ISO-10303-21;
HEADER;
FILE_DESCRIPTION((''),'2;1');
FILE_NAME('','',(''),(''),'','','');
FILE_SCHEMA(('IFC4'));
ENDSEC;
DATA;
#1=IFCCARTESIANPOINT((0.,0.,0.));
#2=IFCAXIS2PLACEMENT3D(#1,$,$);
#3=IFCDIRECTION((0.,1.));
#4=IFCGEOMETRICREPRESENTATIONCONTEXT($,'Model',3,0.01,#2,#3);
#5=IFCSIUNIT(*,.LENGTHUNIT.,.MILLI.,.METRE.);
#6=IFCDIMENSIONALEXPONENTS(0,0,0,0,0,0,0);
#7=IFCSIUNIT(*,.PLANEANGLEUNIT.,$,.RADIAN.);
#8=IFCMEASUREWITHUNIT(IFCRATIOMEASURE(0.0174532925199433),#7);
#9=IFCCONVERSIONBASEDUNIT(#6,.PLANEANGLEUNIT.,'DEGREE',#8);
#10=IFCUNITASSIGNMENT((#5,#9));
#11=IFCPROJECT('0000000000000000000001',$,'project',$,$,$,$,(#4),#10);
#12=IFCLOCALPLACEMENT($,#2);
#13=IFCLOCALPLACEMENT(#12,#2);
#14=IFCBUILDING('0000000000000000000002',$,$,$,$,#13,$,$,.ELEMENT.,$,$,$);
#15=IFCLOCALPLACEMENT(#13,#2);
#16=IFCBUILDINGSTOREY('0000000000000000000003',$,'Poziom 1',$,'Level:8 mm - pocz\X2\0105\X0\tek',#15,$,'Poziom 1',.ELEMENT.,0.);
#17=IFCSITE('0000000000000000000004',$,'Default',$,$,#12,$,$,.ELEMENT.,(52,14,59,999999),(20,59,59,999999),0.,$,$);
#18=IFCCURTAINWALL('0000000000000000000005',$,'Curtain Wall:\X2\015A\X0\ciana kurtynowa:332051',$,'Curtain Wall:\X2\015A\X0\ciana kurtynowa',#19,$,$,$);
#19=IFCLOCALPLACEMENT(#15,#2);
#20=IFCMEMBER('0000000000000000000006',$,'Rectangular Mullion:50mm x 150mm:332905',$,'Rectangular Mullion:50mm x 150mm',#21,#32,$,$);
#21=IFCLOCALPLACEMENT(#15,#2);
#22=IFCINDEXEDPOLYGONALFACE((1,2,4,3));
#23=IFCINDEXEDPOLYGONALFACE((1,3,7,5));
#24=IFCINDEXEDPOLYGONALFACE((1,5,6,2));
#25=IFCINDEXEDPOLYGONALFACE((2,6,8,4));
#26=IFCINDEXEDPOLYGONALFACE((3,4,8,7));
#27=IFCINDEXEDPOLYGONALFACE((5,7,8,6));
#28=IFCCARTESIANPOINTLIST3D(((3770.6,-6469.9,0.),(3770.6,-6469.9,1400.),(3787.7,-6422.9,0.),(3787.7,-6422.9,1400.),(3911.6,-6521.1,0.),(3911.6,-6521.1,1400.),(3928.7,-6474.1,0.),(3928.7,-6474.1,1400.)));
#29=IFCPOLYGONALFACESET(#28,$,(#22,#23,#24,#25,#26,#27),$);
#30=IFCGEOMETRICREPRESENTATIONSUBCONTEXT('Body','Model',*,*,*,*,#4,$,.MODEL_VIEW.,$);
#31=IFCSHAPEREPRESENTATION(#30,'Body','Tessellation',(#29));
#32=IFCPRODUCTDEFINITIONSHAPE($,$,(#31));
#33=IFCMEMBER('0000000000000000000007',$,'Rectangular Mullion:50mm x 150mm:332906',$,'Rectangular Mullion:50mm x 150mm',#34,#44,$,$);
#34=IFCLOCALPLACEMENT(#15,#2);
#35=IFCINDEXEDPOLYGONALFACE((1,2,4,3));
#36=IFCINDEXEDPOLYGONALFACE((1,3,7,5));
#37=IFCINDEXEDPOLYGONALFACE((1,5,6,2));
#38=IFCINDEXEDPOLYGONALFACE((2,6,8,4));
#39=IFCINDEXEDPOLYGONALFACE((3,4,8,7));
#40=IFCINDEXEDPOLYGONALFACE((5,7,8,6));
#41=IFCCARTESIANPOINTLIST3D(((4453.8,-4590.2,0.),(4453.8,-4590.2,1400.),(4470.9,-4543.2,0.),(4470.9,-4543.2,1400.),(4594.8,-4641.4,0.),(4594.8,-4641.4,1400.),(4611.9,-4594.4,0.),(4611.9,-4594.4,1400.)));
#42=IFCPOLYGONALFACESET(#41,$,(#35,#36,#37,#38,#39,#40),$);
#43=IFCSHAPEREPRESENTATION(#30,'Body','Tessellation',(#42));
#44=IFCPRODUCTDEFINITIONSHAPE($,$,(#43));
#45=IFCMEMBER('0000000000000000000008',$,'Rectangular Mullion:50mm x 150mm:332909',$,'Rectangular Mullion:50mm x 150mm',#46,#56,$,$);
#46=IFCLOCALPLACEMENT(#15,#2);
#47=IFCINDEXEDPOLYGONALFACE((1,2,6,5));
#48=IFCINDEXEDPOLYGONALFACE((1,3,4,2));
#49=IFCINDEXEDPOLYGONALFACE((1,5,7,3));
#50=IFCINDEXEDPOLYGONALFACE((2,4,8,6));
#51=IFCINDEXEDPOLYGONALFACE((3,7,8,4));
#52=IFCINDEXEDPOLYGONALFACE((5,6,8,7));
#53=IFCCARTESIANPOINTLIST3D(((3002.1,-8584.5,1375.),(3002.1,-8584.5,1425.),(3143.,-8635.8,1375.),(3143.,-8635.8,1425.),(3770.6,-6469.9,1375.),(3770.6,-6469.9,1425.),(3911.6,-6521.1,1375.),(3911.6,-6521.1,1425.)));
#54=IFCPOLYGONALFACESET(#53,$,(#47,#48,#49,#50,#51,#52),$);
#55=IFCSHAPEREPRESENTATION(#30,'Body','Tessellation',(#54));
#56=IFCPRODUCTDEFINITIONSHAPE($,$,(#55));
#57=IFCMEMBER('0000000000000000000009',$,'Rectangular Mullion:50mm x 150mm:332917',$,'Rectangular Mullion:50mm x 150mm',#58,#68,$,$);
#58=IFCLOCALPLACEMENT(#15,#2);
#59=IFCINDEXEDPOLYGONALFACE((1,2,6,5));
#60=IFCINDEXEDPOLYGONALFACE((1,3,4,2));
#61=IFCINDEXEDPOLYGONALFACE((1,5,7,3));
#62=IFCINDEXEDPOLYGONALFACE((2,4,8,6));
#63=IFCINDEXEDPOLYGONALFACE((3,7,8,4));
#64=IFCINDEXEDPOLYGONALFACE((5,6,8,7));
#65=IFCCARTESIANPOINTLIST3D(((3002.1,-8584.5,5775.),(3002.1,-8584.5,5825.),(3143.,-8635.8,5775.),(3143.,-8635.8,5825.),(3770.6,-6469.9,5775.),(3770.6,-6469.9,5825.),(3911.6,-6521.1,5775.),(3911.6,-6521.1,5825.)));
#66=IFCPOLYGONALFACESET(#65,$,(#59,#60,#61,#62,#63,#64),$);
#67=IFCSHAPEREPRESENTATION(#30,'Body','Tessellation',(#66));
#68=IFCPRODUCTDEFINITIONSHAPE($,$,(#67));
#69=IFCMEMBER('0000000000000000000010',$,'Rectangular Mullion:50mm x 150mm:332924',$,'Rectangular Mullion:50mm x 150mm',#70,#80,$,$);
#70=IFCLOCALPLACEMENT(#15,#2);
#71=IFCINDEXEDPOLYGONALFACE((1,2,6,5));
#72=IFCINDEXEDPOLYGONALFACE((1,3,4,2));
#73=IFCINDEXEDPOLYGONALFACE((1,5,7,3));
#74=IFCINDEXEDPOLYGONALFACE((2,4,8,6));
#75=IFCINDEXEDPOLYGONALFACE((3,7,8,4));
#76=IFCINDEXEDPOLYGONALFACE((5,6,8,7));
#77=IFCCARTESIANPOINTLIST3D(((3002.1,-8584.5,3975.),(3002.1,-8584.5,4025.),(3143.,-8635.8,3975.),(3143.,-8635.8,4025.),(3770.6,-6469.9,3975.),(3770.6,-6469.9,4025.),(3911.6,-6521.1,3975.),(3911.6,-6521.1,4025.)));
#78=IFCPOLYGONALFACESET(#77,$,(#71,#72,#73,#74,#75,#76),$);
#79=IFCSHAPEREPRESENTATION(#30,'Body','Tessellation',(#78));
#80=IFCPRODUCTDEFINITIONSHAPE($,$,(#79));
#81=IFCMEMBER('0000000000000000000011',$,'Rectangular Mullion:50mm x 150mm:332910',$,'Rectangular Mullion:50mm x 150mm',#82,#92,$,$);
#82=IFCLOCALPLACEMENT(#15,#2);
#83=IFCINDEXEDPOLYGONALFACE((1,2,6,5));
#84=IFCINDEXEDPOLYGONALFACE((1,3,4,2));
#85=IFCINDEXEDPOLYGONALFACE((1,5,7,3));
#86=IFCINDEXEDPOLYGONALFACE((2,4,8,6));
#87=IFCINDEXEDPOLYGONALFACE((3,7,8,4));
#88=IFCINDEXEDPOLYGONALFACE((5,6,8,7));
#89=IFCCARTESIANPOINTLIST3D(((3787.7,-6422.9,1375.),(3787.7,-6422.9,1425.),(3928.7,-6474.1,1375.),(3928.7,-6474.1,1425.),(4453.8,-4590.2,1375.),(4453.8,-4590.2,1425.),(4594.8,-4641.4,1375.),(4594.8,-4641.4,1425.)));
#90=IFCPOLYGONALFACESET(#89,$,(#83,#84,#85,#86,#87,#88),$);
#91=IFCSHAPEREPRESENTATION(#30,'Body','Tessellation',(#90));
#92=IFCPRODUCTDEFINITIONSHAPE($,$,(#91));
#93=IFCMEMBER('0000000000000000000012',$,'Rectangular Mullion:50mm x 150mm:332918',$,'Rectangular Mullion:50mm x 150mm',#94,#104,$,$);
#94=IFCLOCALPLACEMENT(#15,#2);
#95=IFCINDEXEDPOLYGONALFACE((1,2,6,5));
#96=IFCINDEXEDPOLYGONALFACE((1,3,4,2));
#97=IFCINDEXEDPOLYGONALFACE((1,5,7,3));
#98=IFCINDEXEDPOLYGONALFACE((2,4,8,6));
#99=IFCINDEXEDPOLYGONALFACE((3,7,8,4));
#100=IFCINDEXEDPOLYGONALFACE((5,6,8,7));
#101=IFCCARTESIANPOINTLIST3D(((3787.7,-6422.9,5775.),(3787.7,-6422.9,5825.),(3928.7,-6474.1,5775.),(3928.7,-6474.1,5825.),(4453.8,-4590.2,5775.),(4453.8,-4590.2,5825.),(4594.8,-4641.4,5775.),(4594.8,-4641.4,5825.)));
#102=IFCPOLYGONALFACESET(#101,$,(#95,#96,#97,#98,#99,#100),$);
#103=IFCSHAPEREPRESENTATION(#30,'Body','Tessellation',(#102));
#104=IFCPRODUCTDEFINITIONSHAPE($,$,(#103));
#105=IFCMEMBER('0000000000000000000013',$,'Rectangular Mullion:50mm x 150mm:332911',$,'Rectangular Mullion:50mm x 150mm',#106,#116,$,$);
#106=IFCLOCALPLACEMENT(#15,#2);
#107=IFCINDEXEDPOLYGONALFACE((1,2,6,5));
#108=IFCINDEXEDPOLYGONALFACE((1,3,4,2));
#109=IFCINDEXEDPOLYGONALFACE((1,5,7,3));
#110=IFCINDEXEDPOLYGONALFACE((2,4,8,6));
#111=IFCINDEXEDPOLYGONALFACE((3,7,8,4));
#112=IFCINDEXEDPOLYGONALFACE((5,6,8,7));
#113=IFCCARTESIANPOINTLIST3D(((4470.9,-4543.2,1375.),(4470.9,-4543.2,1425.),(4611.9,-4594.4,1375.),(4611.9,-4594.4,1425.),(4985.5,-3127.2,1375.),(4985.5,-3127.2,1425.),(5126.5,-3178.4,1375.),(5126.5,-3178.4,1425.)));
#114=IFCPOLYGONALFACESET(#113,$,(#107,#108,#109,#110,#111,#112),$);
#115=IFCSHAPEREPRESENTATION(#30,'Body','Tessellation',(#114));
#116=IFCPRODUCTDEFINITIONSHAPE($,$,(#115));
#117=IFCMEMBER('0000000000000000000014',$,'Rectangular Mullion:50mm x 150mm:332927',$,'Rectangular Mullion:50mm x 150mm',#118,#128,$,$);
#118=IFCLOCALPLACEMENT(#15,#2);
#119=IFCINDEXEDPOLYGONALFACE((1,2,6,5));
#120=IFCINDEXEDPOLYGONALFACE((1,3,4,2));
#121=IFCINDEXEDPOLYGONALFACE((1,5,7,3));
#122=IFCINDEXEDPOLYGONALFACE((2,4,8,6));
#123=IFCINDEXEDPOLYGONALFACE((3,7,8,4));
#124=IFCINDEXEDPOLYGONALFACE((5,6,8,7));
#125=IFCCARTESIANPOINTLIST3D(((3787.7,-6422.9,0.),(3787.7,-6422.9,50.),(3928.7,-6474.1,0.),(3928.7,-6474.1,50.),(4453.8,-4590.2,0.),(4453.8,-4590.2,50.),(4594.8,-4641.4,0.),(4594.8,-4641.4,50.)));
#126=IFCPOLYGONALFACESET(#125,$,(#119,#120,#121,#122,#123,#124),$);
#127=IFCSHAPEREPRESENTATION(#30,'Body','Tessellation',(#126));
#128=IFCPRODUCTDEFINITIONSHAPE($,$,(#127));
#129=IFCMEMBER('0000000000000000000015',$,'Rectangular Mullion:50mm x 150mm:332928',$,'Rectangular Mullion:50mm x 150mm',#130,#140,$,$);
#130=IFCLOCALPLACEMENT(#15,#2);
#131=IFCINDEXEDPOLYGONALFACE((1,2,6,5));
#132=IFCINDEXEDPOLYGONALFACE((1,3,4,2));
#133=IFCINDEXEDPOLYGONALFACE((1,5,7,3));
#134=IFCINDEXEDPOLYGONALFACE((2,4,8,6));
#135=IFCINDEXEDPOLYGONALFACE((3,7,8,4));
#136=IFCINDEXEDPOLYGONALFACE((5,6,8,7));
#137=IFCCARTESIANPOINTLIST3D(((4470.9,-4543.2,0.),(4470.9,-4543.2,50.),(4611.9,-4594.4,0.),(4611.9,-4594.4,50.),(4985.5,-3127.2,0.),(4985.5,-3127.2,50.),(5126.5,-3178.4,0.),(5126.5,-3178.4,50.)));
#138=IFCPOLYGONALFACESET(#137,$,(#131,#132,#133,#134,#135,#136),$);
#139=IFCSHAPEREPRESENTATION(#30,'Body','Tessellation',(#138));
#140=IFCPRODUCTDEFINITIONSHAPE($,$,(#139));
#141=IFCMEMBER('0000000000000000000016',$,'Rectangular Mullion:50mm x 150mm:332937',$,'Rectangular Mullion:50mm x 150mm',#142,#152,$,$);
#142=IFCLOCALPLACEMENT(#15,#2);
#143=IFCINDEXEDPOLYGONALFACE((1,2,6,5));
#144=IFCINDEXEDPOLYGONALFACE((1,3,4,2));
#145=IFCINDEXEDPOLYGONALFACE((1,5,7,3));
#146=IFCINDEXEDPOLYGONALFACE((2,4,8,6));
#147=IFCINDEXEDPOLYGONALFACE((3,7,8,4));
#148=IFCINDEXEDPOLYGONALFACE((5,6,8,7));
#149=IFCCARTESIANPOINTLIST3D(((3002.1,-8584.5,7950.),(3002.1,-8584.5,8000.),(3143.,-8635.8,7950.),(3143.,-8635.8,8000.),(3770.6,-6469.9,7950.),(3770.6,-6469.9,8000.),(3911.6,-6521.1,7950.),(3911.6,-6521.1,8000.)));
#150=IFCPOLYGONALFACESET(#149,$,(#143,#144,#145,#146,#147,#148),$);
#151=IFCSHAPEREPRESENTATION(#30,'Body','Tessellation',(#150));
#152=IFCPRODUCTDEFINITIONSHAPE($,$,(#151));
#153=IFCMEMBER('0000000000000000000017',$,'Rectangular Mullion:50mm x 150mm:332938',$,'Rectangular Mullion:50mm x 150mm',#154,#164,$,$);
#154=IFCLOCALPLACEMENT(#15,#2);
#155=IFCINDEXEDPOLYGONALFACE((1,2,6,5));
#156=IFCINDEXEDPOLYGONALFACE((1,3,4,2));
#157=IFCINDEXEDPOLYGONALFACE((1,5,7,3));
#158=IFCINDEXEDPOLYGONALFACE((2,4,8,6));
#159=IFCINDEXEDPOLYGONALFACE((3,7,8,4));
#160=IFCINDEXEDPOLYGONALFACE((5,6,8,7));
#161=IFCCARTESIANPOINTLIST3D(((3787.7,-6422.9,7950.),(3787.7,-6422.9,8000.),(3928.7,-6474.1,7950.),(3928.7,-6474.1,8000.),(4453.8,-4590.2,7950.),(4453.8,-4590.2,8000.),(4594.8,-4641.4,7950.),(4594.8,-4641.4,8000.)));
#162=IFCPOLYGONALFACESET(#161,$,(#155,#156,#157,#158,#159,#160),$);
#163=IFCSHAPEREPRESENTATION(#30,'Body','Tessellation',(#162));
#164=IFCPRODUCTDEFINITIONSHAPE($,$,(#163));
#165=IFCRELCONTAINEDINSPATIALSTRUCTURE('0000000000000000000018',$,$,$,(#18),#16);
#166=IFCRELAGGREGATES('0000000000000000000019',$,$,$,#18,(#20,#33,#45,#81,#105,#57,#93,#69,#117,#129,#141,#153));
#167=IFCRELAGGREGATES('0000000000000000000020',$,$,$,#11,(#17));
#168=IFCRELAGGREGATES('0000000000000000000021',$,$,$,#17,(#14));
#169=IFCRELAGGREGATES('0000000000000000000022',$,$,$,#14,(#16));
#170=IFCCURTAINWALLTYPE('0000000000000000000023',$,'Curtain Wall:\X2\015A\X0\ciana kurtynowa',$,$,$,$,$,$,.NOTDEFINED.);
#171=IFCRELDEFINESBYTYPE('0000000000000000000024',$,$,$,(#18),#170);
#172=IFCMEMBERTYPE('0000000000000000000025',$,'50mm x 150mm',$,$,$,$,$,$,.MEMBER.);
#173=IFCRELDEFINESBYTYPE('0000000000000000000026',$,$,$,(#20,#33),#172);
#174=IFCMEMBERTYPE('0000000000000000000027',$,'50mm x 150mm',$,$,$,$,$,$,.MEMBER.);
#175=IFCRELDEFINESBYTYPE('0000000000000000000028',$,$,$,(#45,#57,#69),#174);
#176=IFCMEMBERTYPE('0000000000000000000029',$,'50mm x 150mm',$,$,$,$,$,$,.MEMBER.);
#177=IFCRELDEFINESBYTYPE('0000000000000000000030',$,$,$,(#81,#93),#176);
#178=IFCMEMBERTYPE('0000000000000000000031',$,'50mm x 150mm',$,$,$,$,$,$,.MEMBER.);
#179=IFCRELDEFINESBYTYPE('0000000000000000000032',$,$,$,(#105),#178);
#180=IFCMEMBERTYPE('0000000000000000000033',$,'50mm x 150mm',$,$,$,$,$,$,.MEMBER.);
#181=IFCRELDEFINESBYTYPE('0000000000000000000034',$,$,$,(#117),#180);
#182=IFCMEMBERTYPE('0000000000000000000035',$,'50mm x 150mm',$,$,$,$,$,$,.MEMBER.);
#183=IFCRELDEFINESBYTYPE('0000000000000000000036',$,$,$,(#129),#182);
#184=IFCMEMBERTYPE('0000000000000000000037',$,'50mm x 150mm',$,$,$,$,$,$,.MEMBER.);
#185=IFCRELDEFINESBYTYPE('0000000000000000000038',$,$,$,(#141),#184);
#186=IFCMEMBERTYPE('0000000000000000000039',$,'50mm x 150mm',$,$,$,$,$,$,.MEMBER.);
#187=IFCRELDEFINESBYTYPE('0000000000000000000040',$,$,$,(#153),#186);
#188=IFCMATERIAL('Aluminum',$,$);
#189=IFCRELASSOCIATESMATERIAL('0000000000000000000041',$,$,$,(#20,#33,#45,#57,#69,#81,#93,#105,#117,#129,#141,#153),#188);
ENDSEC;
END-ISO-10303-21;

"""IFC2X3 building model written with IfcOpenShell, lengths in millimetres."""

from ifc_helpers import new_model, entity, si_unit, converted_unit, direction, frame, origin, origin_2d_with_axis, place, context, subcontext, project, spatial, rectangle, extrude, source, transform, mapped, material, type_object, type_shapes, element, aggregate, save


model = new_model("IFC2X3")

# Units and contexts
model_context = context("Model", 3, precision=0.01, world=origin(), true_north=direction((0.0, 1.0)))
body_context = subcontext(model_context, "Body", "Model", "MODEL_VIEW")
ifc_project = project(units=[si_unit("LENGTHUNIT", "METRE", prefix="MILLI"), converted_unit("PLANEANGLEUNIT", "DEGREE", entity("IfcRatioMeasure", 0.0174532925199433), si_unit("PLANEANGLEUNIT", "RADIAN"), dimensions=[0, 0, 0, 0, 0, 0, 0])], contexts=[model_context])

# Site, building, storey
site_placement = place(None, origin())
site = spatial("IfcSite", under=ifc_project, at=site_placement, Name="Default", CompositionType="ELEMENT", RefLatitude=(52, 14, 59, 999999), RefLongitude=(20, 59, 59, 999999), RefElevation=0.0)
building_placement = place(site_placement, origin())
building = spatial("IfcBuilding", under=site, at=building_placement, CompositionType="ELEMENT")
storey_placement = place(building_placement, origin())
storey = spatial("IfcBuildingStorey", under=building, at=storey_placement, Name="Poziom 1", ObjectType="Level:8 mm - początek", LongName="Poziom 1", CompositionType="ELEMENT", Elevation=0.0)

# Curtain wall, members
curtain_wall_type = type_object("IfcCurtainWallType", Name="Curtain Wall:Ściana kurtynowa", PredefinedType="NOTDEFINED")
curtain_wall_placement = place(storey_placement, origin())
curtain_wall = element("IfcCurtainWall", 1, at=curtain_wall_placement, inside=storey, type_object=curtain_wall_type, Name="Curtain Wall:Ściana kurtynowa:332051", ObjectType="Curtain Wall:Ściana kurtynowa")
ifc_material_1 = material(Name="Aluminum")
member_type_1 = type_object("IfcMemberType", Name="50mm x 150mm", PredefinedType="MEMBER")
shared_shape_1 = source(origin(), body_context, "Body", "SweptSolid", [
    extrude(rectangle(XDim=150.0, YDim=50.0, at=origin_2d_with_axis()), frame((0.0, 0.0, -1400.0), z_axis=(0.0, 0.0, 1.0), x_axis=(0.0, -1.0, 0.0)), (0.0, 0.0, 1.0), 1400.0),
])
type_shapes(member_type_1, [shared_shape_1])
member_1_placement = place(storey_placement, frame((3849.7, -6472.0, 0.0), z_axis=(0.0, 0.0, -1.0), x_axis=(0.341586, 0.939851, 0.0)))
member_1 = element("IfcMember", 2, at=member_1_placement, type_object=member_type_1, material=ifc_material_1, Name="Rectangular Mullion:50mm x 150mm:332905", ObjectType="Rectangular Mullion:50mm x 150mm", context=body_context, shape_type="MappedRepresentation", body=[
    mapped(shared_shape_1, transform((0.0, 0.0, 0.0), scale=1.0)),
])
member_2_placement = place(storey_placement, frame((4532.8, -4592.3, 0.0), z_axis=(0.0, 0.0, -1.0), x_axis=(0.341586, 0.939851, 0.0)))
member_2 = element("IfcMember", 3, at=member_2_placement, type_object=member_type_1, material=ifc_material_1, Name="Rectangular Mullion:50mm x 150mm:332906", ObjectType="Rectangular Mullion:50mm x 150mm", context=body_context, shape_type="MappedRepresentation", body=[
    mapped(shared_shape_1, transform((0.0, 0.0, 0.0), scale=1.0)),
])
member_type_2 = type_object("IfcMemberType", Name="50mm x 150mm", PredefinedType="MEMBER")
shared_shape_2 = source(origin(), body_context, "Body", "SweptSolid", [
    extrude(rectangle(XDim=150.0, YDim=50.0, at=origin_2d_with_axis()), frame((0.0, 0.0, -2250.0), z_axis=(0.0, 0.0, 1.0), x_axis=(0.0, -1.0, 0.0)), (0.0, 0.0, 1.0), 2250.0),
])
type_shapes(member_type_2, [shared_shape_2])
member_3_placement = place(storey_placement, frame((3841.1, -6495.5, 1400.0), z_axis=(0.341586, 0.939851, 0.0), x_axis=(0.0, 0.0, 1.0)))
member_3 = element("IfcMember", 4, at=member_3_placement, type_object=member_type_2, material=ifc_material_1, Name="Rectangular Mullion:50mm x 150mm:332909", ObjectType="Rectangular Mullion:50mm x 150mm", context=body_context, shape_type="MappedRepresentation", body=[
    mapped(shared_shape_2, transform((0.0, 0.0, 0.0), scale=1.0)),
])
member_4_placement = place(storey_placement, frame((3841.1, -6495.5, 5800.0), z_axis=(0.341586, 0.939851, 0.0), x_axis=(0.0, 0.0, 1.0)))
member_4 = element("IfcMember", 5, at=member_4_placement, type_object=member_type_2, material=ifc_material_1, Name="Rectangular Mullion:50mm x 150mm:332917", ObjectType="Rectangular Mullion:50mm x 150mm", context=body_context, shape_type="MappedRepresentation", body=[
    mapped(shared_shape_2, transform((0.0, 0.0, 0.0), scale=1.0)),
])
member_5_placement = place(storey_placement, frame((3841.1, -6495.5, 4000.0), z_axis=(0.341586, 0.939851, 0.0), x_axis=(0.0, 0.0, 1.0)))
member_5 = element("IfcMember", 6, at=member_5_placement, type_object=member_type_2, material=ifc_material_1, Name="Rectangular Mullion:50mm x 150mm:332924", ObjectType="Rectangular Mullion:50mm x 150mm", context=body_context, shape_type="MappedRepresentation", body=[
    mapped(shared_shape_2, transform((0.0, 0.0, 0.0), scale=1.0)),
])
member_type_3 = type_object("IfcMemberType", Name="50mm x 150mm", PredefinedType="MEMBER")
shared_shape_3 = source(origin(), body_context, "Body", "SweptSolid", [
    extrude(rectangle(XDim=150.0, YDim=50.0, at=origin_2d_with_axis()), frame((0.0, 0.0, -1950.0), z_axis=(0.0, 0.0, 1.0), x_axis=(0.0, -1.0, 0.0)), (0.0, 0.0, 1.0), 1950.0),
])
type_shapes(member_type_3, [shared_shape_3])
member_6_placement = place(storey_placement, frame((4524.3, -4615.8, 1400.0), z_axis=(0.341586, 0.939851, 0.0), x_axis=(0.0, 0.0, 1.0)))
member_6 = element("IfcMember", 7, at=member_6_placement, type_object=member_type_3, material=ifc_material_1, Name="Rectangular Mullion:50mm x 150mm:332910", ObjectType="Rectangular Mullion:50mm x 150mm", context=body_context, shape_type="MappedRepresentation", body=[
    mapped(shared_shape_3, transform((0.0, 0.0, 0.0), scale=1.0)),
])
member_7_placement = place(storey_placement, frame((4524.3, -4615.8, 5800.0), z_axis=(0.341586, 0.939851, 0.0), x_axis=(0.0, 0.0, 1.0)))
member_7 = element("IfcMember", 8, at=member_7_placement, type_object=member_type_3, material=ifc_material_1, Name="Rectangular Mullion:50mm x 150mm:332918", ObjectType="Rectangular Mullion:50mm x 150mm", context=body_context, shape_type="MappedRepresentation", body=[
    mapped(shared_shape_3, transform((0.0, 0.0, 0.0), scale=1.0)),
])
member_type_4 = type_object("IfcMemberType", Name="50mm x 150mm", PredefinedType="MEMBER")
shared_shape_4 = source(origin(), body_context, "Body", "SweptSolid", [
    extrude(rectangle(XDim=150.0, YDim=50.0, at=origin_2d_with_axis()), frame((0.0, 0.0, -1506.6), z_axis=(0.0, 0.0, 1.0), x_axis=(0.0, -1.0, 0.0)), (0.0, 0.0, 1.0), 1506.6),
])
type_shapes(member_type_4, [shared_shape_4])
member_8_placement = place(storey_placement, frame((5056.0, -3152.8, 1400.0), z_axis=(0.341586, 0.939851, 0.0), x_axis=(0.0, 0.0, 1.0)))
member_8 = element("IfcMember", 9, at=member_8_placement, type_object=member_type_4, material=ifc_material_1, Name="Rectangular Mullion:50mm x 150mm:332911", ObjectType="Rectangular Mullion:50mm x 150mm", context=body_context, shape_type="MappedRepresentation", body=[
    mapped(shared_shape_4, transform((0.0, 0.0, 0.0), scale=1.0)),
])
member_type_5 = type_object("IfcMemberType", Name="50mm x 150mm", PredefinedType="MEMBER")
shared_shape_5 = source(origin(), body_context, "Body", "SweptSolid", [
    extrude(rectangle(XDim=150.0, YDim=50.0, at=origin_2d_with_axis()), frame((-25.0, 0.0, -1950.0), z_axis=(0.0, 0.0, 1.0), x_axis=(0.0, -1.0, 0.0)), (0.0, 0.0, 1.0), 1950.0),
])
type_shapes(member_type_5, [shared_shape_5])
member_9_placement = place(storey_placement, frame((3858.2, -6448.5, 0.0), z_axis=(-0.341586, -0.939851, 0.0), x_axis=(0.0, 0.0, -1.0)))
member_9 = element("IfcMember", 10, at=member_9_placement, type_object=member_type_5, material=ifc_material_1, Name="Rectangular Mullion:50mm x 150mm:332927", ObjectType="Rectangular Mullion:50mm x 150mm", context=body_context, shape_type="MappedRepresentation", body=[
    mapped(shared_shape_5, transform((0.0, 0.0, 0.0), scale=1.0)),
])
member_type_6 = type_object("IfcMemberType", Name="50mm x 150mm", PredefinedType="MEMBER")
shared_shape_6 = source(origin(), body_context, "Body", "SweptSolid", [
    extrude(rectangle(XDim=150.0, YDim=50.0, at=origin_2d_with_axis()), frame((-25.0, 0.0, -1506.6), z_axis=(0.0, 0.0, 1.0), x_axis=(0.0, -1.0, 0.0)), (0.0, 0.0, 1.0), 1506.6),
])
type_shapes(member_type_6, [shared_shape_6])
member_10_placement = place(storey_placement, frame((4541.4, -4568.8, 0.0), z_axis=(-0.341586, -0.939851, 0.0), x_axis=(0.0, 0.0, -1.0)))
member_10 = element("IfcMember", 11, at=member_10_placement, type_object=member_type_6, material=ifc_material_1, Name="Rectangular Mullion:50mm x 150mm:332928", ObjectType="Rectangular Mullion:50mm x 150mm", context=body_context, shape_type="MappedRepresentation", body=[
    mapped(shared_shape_6, transform((0.0, 0.0, 0.0), scale=1.0)),
])
member_type_7 = type_object("IfcMemberType", Name="50mm x 150mm", PredefinedType="MEMBER")
shared_shape_7 = source(origin(), body_context, "Body", "SweptSolid", [
    extrude(rectangle(XDim=150.0, YDim=50.0, at=origin_2d_with_axis()), frame((-25.0, 0.0, -2250.0), z_axis=(0.0, 0.0, 1.0), x_axis=(0.0, -1.0, 0.0)), (0.0, 0.0, 1.0), 2250.0),
])
type_shapes(member_type_7, [shared_shape_7])
member_11_placement = place(storey_placement, frame((3841.1, -6495.5, 8000.0), z_axis=(0.341586, 0.939851, 0.0), x_axis=(0.0, 0.0, 1.0)))
member_11 = element("IfcMember", 12, at=member_11_placement, type_object=member_type_7, material=ifc_material_1, Name="Rectangular Mullion:50mm x 150mm:332937", ObjectType="Rectangular Mullion:50mm x 150mm", context=body_context, shape_type="MappedRepresentation", body=[
    mapped(shared_shape_7, transform((0.0, 0.0, 0.0), scale=1.0)),
])
member_type_8 = type_object("IfcMemberType", Name="50mm x 150mm", PredefinedType="MEMBER")
shared_shape_8 = source(origin(), body_context, "Body", "SweptSolid", [
    extrude(rectangle(XDim=150.0, YDim=50.0, at=origin_2d_with_axis()), frame((-25.0, 0.0, -1950.0), z_axis=(0.0, 0.0, 1.0), x_axis=(0.0, -1.0, 0.0)), (0.0, 0.0, 1.0), 1950.0),
])
type_shapes(member_type_8, [shared_shape_8])
member_12_placement = place(storey_placement, frame((4524.3, -4615.8, 8000.0), z_axis=(0.341586, 0.939851, 0.0), x_axis=(0.0, 0.0, 1.0)))
member_12 = element("IfcMember", 13, at=member_12_placement, type_object=member_type_8, material=ifc_material_1, Name="Rectangular Mullion:50mm x 150mm:332938", ObjectType="Rectangular Mullion:50mm x 150mm", context=body_context, shape_type="MappedRepresentation", body=[
    mapped(shared_shape_8, transform((0.0, 0.0, 0.0), scale=1.0)),
])
aggregate(curtain_wall, [member_1, member_2, member_3, member_6, member_8, member_4, member_7, member_5, member_9, member_10, member_11, member_12])

save(model, "model.ifc")
